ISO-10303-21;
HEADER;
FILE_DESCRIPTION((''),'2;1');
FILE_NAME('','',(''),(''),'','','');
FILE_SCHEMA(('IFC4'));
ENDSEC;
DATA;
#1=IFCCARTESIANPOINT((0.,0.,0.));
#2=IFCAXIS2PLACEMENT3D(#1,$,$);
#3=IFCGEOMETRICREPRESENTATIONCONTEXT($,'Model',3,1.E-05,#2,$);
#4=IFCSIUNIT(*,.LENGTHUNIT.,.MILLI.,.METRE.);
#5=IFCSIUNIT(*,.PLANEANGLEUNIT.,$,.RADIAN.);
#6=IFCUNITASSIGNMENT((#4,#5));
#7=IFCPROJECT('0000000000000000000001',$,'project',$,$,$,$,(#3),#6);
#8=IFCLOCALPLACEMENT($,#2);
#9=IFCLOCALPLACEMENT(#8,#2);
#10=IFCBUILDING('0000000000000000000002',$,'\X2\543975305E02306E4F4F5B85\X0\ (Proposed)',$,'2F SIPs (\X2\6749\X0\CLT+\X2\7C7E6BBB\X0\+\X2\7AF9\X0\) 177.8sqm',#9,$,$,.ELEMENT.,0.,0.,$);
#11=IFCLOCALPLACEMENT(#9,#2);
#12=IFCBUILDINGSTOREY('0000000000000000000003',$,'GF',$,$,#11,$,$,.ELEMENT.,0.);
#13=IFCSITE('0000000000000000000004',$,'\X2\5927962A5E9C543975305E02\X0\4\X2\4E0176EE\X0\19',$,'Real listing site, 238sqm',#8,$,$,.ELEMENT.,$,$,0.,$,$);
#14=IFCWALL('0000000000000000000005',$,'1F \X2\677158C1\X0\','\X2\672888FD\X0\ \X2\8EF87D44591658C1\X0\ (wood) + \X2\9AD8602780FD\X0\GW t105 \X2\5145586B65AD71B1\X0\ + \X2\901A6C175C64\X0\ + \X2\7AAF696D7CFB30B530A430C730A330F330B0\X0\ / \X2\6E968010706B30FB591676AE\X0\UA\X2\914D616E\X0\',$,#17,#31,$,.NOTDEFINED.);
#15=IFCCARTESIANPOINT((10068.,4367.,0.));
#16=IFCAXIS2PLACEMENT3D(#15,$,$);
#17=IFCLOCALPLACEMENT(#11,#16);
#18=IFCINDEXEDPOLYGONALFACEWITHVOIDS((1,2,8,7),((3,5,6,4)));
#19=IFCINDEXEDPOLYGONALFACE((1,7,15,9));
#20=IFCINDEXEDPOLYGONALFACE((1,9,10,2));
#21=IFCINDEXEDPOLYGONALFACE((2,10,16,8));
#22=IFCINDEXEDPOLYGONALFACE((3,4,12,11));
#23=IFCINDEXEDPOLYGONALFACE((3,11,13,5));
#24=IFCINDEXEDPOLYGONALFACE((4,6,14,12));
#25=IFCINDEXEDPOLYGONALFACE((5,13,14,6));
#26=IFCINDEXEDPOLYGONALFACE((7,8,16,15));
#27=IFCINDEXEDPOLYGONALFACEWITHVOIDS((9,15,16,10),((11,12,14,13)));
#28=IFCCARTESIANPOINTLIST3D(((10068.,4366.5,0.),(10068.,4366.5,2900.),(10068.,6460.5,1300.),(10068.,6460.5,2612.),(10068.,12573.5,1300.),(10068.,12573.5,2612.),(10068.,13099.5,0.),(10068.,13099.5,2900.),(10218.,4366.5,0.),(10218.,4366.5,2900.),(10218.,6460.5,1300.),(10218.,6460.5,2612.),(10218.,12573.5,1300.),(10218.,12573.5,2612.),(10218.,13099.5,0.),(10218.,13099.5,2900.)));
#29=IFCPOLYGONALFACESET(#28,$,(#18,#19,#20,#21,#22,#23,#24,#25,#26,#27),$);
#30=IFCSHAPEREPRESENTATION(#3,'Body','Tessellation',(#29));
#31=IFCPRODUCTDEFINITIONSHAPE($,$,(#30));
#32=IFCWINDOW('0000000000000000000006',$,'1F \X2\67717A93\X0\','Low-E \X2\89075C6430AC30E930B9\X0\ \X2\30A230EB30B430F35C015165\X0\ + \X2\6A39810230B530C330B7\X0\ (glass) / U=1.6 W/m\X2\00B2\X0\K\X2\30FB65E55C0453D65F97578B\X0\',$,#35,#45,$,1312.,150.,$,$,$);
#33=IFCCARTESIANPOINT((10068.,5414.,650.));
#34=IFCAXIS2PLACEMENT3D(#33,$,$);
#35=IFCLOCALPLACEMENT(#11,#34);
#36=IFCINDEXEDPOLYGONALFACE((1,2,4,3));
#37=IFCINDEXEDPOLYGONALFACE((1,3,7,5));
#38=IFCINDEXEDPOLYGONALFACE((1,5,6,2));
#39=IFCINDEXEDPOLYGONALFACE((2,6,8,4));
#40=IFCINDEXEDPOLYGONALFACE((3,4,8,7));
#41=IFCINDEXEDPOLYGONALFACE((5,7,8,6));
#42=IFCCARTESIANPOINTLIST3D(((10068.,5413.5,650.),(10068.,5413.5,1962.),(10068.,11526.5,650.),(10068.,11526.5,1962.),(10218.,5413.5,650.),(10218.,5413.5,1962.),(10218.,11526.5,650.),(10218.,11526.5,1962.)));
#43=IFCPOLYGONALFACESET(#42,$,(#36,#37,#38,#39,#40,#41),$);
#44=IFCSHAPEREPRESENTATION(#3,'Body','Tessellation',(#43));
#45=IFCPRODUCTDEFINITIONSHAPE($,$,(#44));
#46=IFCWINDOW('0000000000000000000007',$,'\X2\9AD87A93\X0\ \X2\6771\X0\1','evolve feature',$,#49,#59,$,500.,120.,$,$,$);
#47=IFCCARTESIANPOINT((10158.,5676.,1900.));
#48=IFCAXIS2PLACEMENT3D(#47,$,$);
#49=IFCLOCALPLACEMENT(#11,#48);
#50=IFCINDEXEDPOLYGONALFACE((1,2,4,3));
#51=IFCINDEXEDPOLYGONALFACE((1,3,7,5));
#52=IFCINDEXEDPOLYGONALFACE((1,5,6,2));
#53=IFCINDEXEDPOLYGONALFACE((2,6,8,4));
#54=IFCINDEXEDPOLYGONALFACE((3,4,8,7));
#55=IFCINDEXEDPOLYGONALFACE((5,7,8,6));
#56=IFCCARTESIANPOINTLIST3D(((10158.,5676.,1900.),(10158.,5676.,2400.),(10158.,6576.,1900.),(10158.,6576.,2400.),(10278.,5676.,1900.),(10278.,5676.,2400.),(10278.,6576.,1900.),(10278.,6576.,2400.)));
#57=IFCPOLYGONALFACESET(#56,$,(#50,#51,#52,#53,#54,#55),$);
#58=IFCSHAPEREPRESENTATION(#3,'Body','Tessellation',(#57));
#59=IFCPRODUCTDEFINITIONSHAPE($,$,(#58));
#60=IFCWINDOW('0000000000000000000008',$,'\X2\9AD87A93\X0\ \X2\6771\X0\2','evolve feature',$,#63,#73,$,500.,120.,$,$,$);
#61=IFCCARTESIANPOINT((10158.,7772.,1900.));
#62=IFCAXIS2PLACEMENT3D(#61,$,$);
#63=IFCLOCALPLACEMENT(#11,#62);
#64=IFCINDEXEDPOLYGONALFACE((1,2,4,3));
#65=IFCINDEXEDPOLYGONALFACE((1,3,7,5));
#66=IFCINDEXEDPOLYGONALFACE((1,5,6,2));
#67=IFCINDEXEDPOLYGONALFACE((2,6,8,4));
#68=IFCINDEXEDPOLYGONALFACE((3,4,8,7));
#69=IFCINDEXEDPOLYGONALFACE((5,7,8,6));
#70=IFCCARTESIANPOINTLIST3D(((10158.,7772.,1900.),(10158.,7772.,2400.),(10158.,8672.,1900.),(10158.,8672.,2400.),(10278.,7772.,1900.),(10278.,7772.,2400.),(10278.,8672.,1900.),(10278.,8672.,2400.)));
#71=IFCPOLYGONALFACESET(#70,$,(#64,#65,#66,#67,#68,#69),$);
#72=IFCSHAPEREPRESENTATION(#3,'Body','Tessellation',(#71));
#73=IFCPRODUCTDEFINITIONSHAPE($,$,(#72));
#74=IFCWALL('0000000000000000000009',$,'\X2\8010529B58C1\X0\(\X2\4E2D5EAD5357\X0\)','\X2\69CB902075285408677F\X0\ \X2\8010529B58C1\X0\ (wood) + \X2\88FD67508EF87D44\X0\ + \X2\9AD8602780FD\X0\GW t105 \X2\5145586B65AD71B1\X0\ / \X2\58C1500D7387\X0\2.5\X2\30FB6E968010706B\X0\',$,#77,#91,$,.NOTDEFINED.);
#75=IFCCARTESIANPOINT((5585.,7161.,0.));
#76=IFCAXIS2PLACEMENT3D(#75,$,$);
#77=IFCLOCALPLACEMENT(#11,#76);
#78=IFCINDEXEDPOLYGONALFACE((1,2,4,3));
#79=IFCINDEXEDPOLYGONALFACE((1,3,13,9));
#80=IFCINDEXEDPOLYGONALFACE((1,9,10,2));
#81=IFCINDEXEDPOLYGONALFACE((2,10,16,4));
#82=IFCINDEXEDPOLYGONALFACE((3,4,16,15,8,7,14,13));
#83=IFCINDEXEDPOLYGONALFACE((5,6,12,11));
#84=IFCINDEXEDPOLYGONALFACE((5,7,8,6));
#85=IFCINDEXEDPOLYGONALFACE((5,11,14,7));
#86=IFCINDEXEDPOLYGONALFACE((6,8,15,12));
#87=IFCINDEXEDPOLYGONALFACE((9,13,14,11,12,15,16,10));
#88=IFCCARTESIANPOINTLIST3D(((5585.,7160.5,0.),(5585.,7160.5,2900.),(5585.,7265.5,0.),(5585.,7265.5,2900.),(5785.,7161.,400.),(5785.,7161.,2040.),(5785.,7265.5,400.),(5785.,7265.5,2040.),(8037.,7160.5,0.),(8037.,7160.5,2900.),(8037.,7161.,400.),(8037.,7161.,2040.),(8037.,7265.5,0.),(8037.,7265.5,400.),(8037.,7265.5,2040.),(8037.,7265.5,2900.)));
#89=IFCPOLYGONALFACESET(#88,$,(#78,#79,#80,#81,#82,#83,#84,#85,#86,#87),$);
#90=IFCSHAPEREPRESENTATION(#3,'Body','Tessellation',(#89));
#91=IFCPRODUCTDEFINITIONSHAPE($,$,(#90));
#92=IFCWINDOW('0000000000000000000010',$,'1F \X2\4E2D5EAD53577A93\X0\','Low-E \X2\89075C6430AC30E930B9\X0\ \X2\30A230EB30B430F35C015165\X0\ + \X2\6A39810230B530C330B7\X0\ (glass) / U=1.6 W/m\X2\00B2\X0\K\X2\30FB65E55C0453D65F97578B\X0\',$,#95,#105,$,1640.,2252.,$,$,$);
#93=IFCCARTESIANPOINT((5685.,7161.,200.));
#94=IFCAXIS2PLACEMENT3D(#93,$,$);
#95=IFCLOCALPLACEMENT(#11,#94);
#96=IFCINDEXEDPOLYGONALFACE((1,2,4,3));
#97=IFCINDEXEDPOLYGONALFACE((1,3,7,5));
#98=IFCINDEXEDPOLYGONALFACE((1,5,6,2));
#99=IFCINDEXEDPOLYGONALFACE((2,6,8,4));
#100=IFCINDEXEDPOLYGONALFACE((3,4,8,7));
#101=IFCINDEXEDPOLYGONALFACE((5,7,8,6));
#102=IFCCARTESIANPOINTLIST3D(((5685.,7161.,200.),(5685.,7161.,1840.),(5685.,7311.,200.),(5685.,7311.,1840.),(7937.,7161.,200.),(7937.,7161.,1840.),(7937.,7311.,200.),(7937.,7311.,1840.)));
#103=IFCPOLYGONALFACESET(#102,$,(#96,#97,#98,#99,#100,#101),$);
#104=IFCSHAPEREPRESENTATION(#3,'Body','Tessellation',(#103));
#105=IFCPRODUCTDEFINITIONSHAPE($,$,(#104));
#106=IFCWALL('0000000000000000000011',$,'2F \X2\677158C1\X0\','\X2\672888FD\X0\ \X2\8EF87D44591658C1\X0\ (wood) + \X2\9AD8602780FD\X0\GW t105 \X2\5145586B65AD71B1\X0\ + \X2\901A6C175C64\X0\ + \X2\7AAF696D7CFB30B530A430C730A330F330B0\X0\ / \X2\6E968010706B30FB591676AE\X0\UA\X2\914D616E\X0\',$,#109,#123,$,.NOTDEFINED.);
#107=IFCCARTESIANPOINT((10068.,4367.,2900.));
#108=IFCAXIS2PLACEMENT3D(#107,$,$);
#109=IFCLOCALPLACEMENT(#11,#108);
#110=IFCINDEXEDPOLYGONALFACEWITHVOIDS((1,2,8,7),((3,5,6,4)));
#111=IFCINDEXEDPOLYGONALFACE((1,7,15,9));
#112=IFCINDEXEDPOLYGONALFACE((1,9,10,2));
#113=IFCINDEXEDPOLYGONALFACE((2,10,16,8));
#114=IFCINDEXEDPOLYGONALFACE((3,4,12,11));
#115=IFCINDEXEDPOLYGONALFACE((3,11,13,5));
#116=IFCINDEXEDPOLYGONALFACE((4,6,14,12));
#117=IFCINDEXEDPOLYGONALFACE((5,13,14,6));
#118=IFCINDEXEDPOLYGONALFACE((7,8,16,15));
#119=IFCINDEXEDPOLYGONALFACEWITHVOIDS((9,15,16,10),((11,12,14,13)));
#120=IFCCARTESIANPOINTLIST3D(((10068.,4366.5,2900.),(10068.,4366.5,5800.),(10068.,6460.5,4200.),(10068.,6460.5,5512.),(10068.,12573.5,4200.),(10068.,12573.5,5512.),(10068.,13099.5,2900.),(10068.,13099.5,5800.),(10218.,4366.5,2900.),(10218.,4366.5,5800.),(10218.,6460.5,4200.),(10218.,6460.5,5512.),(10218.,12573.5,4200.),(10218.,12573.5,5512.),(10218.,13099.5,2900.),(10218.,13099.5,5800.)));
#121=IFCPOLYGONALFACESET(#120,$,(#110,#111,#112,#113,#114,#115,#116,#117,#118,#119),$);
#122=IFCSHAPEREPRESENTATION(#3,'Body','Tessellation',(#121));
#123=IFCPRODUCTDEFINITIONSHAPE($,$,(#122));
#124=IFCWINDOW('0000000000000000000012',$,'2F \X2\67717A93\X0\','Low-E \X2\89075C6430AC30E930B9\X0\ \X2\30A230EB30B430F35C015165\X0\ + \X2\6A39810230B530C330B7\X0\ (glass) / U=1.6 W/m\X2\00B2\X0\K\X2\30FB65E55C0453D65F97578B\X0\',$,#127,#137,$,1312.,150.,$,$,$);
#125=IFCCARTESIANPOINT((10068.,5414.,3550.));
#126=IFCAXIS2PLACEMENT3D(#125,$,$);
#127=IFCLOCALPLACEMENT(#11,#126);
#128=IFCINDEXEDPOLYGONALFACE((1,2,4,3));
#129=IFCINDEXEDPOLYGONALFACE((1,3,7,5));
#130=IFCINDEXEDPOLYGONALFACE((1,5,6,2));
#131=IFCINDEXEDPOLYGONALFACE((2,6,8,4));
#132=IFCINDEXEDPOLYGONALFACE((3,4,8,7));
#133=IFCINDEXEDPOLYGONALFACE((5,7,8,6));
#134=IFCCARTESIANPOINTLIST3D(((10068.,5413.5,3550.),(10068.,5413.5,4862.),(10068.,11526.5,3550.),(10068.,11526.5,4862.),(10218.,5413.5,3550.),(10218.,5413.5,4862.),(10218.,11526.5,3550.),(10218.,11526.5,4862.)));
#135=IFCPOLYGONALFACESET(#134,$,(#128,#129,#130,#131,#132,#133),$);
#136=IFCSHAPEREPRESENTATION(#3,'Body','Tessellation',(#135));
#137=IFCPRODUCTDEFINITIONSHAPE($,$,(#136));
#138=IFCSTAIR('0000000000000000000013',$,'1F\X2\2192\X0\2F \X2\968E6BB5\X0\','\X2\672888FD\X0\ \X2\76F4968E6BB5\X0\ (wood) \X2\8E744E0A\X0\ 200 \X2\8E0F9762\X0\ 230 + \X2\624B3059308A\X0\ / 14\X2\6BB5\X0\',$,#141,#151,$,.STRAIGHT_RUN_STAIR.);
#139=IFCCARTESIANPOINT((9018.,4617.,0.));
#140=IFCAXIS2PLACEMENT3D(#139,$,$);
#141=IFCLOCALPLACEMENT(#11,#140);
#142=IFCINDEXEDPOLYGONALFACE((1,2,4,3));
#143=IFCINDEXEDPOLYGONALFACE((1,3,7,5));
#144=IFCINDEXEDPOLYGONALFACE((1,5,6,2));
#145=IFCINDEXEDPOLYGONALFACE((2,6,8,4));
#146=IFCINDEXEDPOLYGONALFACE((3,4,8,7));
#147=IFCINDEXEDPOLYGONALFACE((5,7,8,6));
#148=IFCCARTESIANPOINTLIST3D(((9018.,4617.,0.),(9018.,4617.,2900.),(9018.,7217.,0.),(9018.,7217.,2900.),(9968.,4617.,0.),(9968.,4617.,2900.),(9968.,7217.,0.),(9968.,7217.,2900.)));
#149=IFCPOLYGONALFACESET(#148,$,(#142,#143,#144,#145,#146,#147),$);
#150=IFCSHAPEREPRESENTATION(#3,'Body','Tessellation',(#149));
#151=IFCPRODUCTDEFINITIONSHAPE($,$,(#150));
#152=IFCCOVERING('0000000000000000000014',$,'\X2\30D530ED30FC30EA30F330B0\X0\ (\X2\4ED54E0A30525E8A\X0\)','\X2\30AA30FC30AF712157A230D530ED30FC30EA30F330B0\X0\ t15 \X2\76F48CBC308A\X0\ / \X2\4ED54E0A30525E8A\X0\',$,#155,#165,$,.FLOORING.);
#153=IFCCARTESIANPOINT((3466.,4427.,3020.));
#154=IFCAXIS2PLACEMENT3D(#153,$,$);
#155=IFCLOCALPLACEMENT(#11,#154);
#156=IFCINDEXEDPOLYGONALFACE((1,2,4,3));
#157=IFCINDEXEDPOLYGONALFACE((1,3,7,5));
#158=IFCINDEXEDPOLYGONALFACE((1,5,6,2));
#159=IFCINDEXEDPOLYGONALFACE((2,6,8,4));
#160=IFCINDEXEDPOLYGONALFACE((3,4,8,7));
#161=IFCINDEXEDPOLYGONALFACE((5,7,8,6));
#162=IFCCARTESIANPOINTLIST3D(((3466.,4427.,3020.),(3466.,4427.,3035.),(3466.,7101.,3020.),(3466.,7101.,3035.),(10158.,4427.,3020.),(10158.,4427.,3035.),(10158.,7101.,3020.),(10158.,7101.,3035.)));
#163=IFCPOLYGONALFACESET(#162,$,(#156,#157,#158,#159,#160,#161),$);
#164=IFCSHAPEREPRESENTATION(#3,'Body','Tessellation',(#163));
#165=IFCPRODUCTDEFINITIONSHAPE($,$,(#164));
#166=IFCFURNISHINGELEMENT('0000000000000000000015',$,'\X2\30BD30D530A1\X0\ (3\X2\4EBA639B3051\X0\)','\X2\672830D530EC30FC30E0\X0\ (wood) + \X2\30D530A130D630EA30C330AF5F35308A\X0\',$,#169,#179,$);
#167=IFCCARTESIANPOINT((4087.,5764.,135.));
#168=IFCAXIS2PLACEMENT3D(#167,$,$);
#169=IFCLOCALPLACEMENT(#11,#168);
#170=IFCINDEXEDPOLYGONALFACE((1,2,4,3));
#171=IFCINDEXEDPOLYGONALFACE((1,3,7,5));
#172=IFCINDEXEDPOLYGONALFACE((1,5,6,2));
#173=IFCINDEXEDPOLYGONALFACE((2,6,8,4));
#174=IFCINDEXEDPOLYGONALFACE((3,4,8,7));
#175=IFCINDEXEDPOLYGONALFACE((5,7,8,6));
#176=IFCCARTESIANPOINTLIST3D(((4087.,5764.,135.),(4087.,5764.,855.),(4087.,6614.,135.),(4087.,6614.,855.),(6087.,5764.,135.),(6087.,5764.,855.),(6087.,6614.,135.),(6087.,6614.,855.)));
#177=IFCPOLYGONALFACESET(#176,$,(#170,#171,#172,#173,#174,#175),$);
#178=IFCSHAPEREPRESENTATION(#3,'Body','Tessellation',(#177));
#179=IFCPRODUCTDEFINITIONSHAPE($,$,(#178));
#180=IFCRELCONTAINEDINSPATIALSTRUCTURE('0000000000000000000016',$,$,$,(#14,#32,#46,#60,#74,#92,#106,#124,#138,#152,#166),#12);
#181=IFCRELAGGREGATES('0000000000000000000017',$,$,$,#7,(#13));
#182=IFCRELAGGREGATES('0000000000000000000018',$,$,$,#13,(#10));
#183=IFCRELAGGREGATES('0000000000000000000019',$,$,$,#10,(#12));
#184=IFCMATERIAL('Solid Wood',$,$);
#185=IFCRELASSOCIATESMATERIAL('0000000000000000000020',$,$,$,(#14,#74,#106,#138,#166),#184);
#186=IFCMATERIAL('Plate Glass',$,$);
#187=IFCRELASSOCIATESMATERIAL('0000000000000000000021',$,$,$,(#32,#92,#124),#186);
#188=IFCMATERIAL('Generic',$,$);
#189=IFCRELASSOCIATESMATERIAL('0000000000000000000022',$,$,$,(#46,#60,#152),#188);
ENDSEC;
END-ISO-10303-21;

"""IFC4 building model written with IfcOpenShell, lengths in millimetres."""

from ifc_helpers import new_model, si_unit, frame, frame_2d, origin, place, context, project, spatial, rectangle, extrude, material, element, fill, save


model = new_model("IFC4")

# Units and contexts
model_context = context("Model", 3, precision=1e-05, world=origin())
ifc_project = project(units=[si_unit("LENGTHUNIT", "METRE", prefix="MILLI"), si_unit("PLANEANGLEUNIT", "RADIAN")], contexts=[model_context])

# Site, building, storey
site_placement = place(None, origin())
site = spatial("IfcSite", under=ifc_project, at=site_placement, Name="大阪府吹田市4丁目19", ObjectType="Real listing site, 238sqm", CompositionType="ELEMENT", RefElevation=0.0)
building_placement = place(site_placement, origin())
building = spatial("IfcBuilding", under=site, at=building_placement, Name="吹田市の住宅 (Proposed)", ObjectType="2F SIPs (杉CLT+籾殻+竹) 177.8sqm", CompositionType="ELEMENT", ElevationOfRefHeight=0.0, ElevationOfTerrain=0.0)
storey_placement = place(building_placement, origin())
storey = spatial("IfcBuildingStorey", under=building, at=storey_placement, Name="GF", CompositionType="ELEMENT", Elevation=0.0)

# Shared definitions
ifc_material_1 = material(Name="Solid Wood")

# Wall, openings, windows
wall_1_placement = place(storey_placement, frame((10068.0, 4367.0, 0.0)))
wall_1 = element("IfcWall", 1, at=wall_1_placement, inside=storey, material=ifc_material_1, Name="1F 東壁", Description="木製 軸組外壁 (wood) + 高性能GW t105 充填断熱 + 通気層 + 窯業系サイディング / 準耐火・外皮UA配慮", PredefinedType="NOTDEFINED", context=model_context, shape_type="SweptSolid", body=[
    extrude(rectangle(XDim=150.0, YDim=8733.0, at=frame_2d((75.0, 4366.0))), frame((10068.0, 4367.0, 0.0)), (0.0, 0.0, 1.0), 2900.0),
])
opening_1_placement = place(storey_placement, frame((10068.0, 5414.0, 650.0)))
opening_1 = element("IfcOpeningElement", 2, at=opening_1_placement, cuts=wall_1, PredefinedType="NOTDEFINED", context=model_context, shape_type="SweptSolid", body=[
    extrude(rectangle(XDim=150.0, YDim=6113.0, at=frame_2d((75.0, 3056.0))), frame((10068.0, 5414.0, 650.0)), (0.0, 0.0, 1.0), 1312.0),
])
opening_2_placement = place(storey_placement, frame((10158.0, 5676.0, 1900.0)))
opening_2 = element("IfcOpeningElement", 3, at=opening_2_placement, cuts=wall_1, PredefinedType="NOTDEFINED", context=model_context, shape_type="SweptSolid", body=[
    extrude(rectangle(XDim=120.0, YDim=900.0, at=frame_2d((60.0, 450.0))), frame((10158.0, 5676.0, 1900.0)), (0.0, 0.0, 1.0), 500.0),
])
opening_3_placement = place(storey_placement, frame((10158.0, 7772.0, 1900.0)))
opening_3 = element("IfcOpeningElement", 4, at=opening_3_placement, cuts=wall_1, PredefinedType="NOTDEFINED", context=model_context, shape_type="SweptSolid", body=[
    extrude(rectangle(XDim=120.0, YDim=900.0, at=frame_2d((60.0, 450.0))), frame((10158.0, 7772.0, 1900.0)), (0.0, 0.0, 1.0), 500.0),
])
ifc_material_2 = material(Name="Plate Glass")
window_1_placement = place(storey_placement, frame((10068.0, 5414.0, 650.0)))
window_1 = element("IfcWindow", 5, at=window_1_placement, inside=storey, material=ifc_material_2, Name="1F 東窓", Description="Low-E 複層ガラス アルゴン封入 + 樹脂サッシ (glass) / U=1.6 W/m²K・日射取得型", OverallHeight=1312.0, OverallWidth=150.0, context=model_context, shape_type="SweptSolid", body=[
    extrude(rectangle(XDim=150.0, YDim=6113.0, at=frame_2d((75.0, 3056.0))), frame((10068.0, 5414.0, 650.0)), (0.0, 0.0, 1.0), 1312.0),
])
fill(opening_1, window_1)
ifc_material_3 = material(Name="Generic")
window_2_placement = place(storey_placement, frame((10158.0, 5676.0, 1900.0)))
window_2 = element("IfcWindow", 6, at=window_2_placement, inside=storey, material=ifc_material_3, Name="高窓 東1", Description="evolve feature", OverallHeight=500.0, OverallWidth=120.0, context=model_context, shape_type="SweptSolid", body=[
    extrude(rectangle(XDim=120.0, YDim=900.0, at=frame_2d((60.0, 450.0))), frame((10158.0, 5676.0, 1900.0)), (0.0, 0.0, 1.0), 500.0),
])
fill(opening_2, window_2)
window_3_placement = place(storey_placement, frame((10158.0, 7772.0, 1900.0)))
window_3 = element("IfcWindow", 7, at=window_3_placement, inside=storey, material=ifc_material_3, Name="高窓 東2", Description="evolve feature", OverallHeight=500.0, OverallWidth=120.0, context=model_context, shape_type="SweptSolid", body=[
    extrude(rectangle(XDim=120.0, YDim=900.0, at=frame_2d((60.0, 450.0))), frame((10158.0, 7772.0, 1900.0)), (0.0, 0.0, 1.0), 500.0),
])
fill(opening_3, window_3)

# Wall, opening, window
wall_2_placement = place(storey_placement, frame((5585.0, 7161.0, 0.0)))
wall_2 = element("IfcWall", 8, at=wall_2_placement, inside=storey, material=ifc_material_1, Name="耐力壁(中庭南)", Description="構造用合板 耐力壁 (wood) + 製材軸組 + 高性能GW t105 充填断熱 / 壁倍率2.5・準耐火", PredefinedType="NOTDEFINED", context=model_context, shape_type="SweptSolid", body=[
    extrude(rectangle(XDim=2452.0, YDim=105.0, at=frame_2d((1226.0, 52.0))), frame((5585.0, 7161.0, 0.0)), (0.0, 0.0, 1.0), 2900.0),
])
opening_4_placement = place(storey_placement, frame((5685.0, 7161.0, 200.0)))
opening_4 = element("IfcOpeningElement", 9, at=opening_4_placement, cuts=wall_2, PredefinedType="NOTDEFINED", context=model_context, shape_type="SweptSolid", body=[
    extrude(rectangle(XDim=2252.0, YDim=150.0, at=frame_2d((1126.0, 75.0))), frame((5685.0, 7161.0, 200.0)), (0.0, 0.0, 1.0), 1640.0),
])
window_4_placement = place(storey_placement, frame((5685.0, 7161.0, 200.0)))
window_4 = element("IfcWindow", 10, at=window_4_placement, inside=storey, material=ifc_material_2, Name="1F 中庭南窓", Description="Low-E 複層ガラス アルゴン封入 + 樹脂サッシ (glass) / U=1.6 W/m²K・日射取得型", OverallHeight=1640.0, OverallWidth=2252.0, context=model_context, shape_type="SweptSolid", body=[
    extrude(rectangle(XDim=2252.0, YDim=150.0, at=frame_2d((1126.0, 75.0))), frame((5685.0, 7161.0, 200.0)), (0.0, 0.0, 1.0), 1640.0),
])
fill(opening_4, window_4)

# Wall, opening, window
wall_3_placement = place(storey_placement, frame((10068.0, 4367.0, 2900.0)))
wall_3 = element("IfcWall", 11, at=wall_3_placement, inside=storey, material=ifc_material_1, Name="2F 東壁", Description="木製 軸組外壁 (wood) + 高性能GW t105 充填断熱 + 通気層 + 窯業系サイディング / 準耐火・外皮UA配慮", PredefinedType="NOTDEFINED", context=model_context, shape_type="SweptSolid", body=[
    extrude(rectangle(XDim=150.0, YDim=8733.0, at=frame_2d((75.0, 4366.0))), frame((10068.0, 4367.0, 2900.0)), (0.0, 0.0, 1.0), 2900.0),
])
opening_5_placement = place(storey_placement, frame((10068.0, 5414.0, 3550.0)))
opening_5 = element("IfcOpeningElement", 12, at=opening_5_placement, cuts=wall_3, PredefinedType="NOTDEFINED", context=model_context, shape_type="SweptSolid", body=[
    extrude(rectangle(XDim=150.0, YDim=6113.0, at=frame_2d((75.0, 3056.0))), frame((10068.0, 5414.0, 3550.0)), (0.0, 0.0, 1.0), 1312.0),
])
window_5_placement = place(storey_placement, frame((10068.0, 5414.0, 3550.0)))
window_5 = element("IfcWindow", 13, at=window_5_placement, inside=storey, material=ifc_material_2, Name="2F 東窓", Description="Low-E 複層ガラス アルゴン封入 + 樹脂サッシ (glass) / U=1.6 W/m²K・日射取得型", OverallHeight=1312.0, OverallWidth=150.0, context=model_context, shape_type="SweptSolid", body=[
    extrude(rectangle(XDim=150.0, YDim=6113.0, at=frame_2d((75.0, 3056.0))), frame((10068.0, 5414.0, 3550.0)), (0.0, 0.0, 1.0), 1312.0),
])
fill(opening_5, window_5)

# Stair
stair_placement = place(storey_placement, frame((9018.0, 4617.0, 0.0)))
element("IfcStair", 14, at=stair_placement, inside=storey, material=ifc_material_1, Name="1F→2F 階段", Description="木製 直階段 (wood) 蹴上 200 踏面 230 + 手すり / 14段", PredefinedType="STRAIGHT_RUN_STAIR", context=model_context, shape_type="SweptSolid", body=[
    extrude(rectangle(XDim=950.0, YDim=2600.0, at=frame_2d((475.0, 1300.0))), frame((9018.0, 4617.0, 0.0)), (0.0, 0.0, 1.0), 2900.0),
])

# Covering
covering_placement = place(storey_placement, frame((3466.0, 4427.0, 3020.0)))
element("IfcCovering", 15, at=covering_placement, inside=storey, material=ifc_material_3, Name="フローリング (仕上げ床)", Description="オーク無垢フローリング t15 直貼り / 仕上げ床", PredefinedType="FLOORING", context=model_context, shape_type="SweptSolid", body=[
    extrude(rectangle(XDim=6692.0, YDim=2674.0, at=frame_2d((3346.0, 1337.0))), frame((3466.0, 4427.0, 3020.0)), (0.0, 0.0, 1.0), 15.0),
])

# Furnishing element
furnishing_1_placement = place(storey_placement, frame((4087.0, 5764.0, 135.0)))
element("IfcFurnishingElement", 16, at=furnishing_1_placement, inside=storey, material=ifc_material_1, Name="ソファ (3人掛け)", Description="木フレーム (wood) + ファブリック張り", context=model_context, shape_type="SweptSolid", body=[
    extrude(rectangle(XDim=2000.0, YDim=850.0, at=frame_2d((1000.0, 425.0))), frame((4087.0, 5764.0, 135.0)), (0.0, 0.0, 1.0), 720.0),
])

save(model, "model.ifc")
